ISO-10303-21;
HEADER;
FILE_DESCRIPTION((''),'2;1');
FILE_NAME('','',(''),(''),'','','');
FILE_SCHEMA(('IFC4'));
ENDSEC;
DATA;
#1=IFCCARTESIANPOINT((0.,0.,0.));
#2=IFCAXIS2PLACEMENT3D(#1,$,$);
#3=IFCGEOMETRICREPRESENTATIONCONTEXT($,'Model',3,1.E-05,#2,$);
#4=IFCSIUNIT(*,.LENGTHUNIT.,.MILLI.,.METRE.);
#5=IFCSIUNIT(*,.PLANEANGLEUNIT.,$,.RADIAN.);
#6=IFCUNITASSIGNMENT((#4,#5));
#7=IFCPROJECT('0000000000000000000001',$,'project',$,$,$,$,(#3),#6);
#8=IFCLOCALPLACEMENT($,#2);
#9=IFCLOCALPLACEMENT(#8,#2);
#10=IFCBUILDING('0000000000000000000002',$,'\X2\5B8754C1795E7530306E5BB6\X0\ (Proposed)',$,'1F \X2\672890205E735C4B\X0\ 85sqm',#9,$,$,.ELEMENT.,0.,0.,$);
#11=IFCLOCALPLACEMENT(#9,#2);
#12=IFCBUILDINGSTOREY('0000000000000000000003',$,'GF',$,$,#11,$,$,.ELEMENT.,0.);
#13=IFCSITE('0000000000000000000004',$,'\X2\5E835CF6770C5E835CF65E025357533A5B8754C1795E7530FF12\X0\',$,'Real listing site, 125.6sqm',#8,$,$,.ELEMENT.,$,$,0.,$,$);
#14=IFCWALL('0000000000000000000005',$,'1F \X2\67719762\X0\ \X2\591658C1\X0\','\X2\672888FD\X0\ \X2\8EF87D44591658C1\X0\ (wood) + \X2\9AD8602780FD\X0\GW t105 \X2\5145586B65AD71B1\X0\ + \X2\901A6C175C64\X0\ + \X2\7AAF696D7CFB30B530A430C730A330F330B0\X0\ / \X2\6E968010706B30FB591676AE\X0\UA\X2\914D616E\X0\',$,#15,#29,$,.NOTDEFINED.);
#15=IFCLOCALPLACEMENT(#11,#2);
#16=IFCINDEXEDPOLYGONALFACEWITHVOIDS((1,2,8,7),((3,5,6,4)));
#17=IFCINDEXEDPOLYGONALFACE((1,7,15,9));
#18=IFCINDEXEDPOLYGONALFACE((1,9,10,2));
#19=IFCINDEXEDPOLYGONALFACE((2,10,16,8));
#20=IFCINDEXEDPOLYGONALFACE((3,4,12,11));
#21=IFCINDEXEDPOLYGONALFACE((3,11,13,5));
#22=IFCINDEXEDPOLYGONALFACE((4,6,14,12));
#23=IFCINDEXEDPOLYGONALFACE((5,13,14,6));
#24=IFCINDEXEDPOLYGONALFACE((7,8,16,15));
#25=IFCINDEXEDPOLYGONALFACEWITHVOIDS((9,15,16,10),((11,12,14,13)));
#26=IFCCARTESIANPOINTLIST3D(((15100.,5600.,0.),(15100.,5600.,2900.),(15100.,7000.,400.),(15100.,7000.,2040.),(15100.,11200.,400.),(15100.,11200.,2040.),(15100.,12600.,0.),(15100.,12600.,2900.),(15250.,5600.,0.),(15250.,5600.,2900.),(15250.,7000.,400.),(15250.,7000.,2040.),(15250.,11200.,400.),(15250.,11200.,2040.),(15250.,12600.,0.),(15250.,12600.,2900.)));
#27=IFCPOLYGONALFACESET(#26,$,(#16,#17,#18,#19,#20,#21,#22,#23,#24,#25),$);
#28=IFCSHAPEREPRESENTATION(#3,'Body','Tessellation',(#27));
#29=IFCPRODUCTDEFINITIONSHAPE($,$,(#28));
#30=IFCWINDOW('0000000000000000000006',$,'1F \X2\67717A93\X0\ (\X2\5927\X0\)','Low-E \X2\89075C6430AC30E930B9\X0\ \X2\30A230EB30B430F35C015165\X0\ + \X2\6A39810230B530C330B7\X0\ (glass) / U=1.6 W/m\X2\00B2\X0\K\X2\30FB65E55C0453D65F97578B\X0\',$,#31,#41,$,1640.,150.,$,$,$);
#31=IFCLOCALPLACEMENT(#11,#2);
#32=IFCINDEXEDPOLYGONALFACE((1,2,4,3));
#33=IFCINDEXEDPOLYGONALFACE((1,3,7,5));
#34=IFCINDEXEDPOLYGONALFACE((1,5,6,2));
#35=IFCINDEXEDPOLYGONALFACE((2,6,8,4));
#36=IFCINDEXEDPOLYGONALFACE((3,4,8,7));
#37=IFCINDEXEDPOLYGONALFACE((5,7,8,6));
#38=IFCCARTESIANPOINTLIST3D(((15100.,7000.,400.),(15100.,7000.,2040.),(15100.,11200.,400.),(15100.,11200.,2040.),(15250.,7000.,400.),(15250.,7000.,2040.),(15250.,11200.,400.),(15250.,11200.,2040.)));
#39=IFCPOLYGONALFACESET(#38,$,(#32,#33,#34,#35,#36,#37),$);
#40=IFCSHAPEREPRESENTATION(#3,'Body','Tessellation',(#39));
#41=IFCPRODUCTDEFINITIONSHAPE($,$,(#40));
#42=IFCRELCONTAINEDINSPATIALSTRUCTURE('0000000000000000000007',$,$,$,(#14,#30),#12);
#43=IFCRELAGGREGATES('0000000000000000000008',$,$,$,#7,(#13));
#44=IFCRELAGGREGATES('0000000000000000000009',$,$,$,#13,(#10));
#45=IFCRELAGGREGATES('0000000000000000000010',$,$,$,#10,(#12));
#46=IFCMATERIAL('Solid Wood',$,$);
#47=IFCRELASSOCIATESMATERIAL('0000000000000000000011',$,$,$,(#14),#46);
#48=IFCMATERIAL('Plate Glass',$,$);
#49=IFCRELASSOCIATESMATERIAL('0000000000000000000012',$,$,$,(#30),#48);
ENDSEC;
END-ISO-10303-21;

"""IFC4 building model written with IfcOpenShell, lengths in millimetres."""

from ifc_helpers import new_model, si_unit, frame, frame_2d, origin, place, context, project, spatial, rectangle, extrude, material, element, fill, save


model = new_model("IFC4")

# Units and contexts
model_context = context("Model", 3, precision=1e-05, world=origin())
ifc_project = project(units=[si_unit("LENGTHUNIT", "METRE", prefix="MILLI"), si_unit("PLANEANGLEUNIT", "RADIAN")], contexts=[model_context])

# Site, building, storey
site_placement = place(None, origin())
site = spatial("IfcSite", under=ifc_project, at=site_placement, Name="広島県広島市南区宇品神田２", ObjectType="Real listing site, 125.6sqm", CompositionType="ELEMENT", RefElevation=0.0)
building_placement = place(site_placement, origin())
building = spatial("IfcBuilding", under=site, at=building_placement, Name="宇品神田の家 (Proposed)", ObjectType="1F 木造平屋 85sqm", CompositionType="ELEMENT", ElevationOfRefHeight=0.0, ElevationOfTerrain=0.0)
storey_placement = place(building_placement, origin())
storey = spatial("IfcBuildingStorey", under=building, at=storey_placement, Name="GF", CompositionType="ELEMENT", Elevation=0.0)

# Shared definitions
ifc_material_1 = material(Name="Solid Wood")

# Shared definitions
ifc_material_2 = material(Name="Plate Glass")

# Wall, opening, window
wall_1_placement = place(storey_placement, frame((7550.0, 2800.0, 0.0)))
wall_1 = element("IfcWall", 1, at=wall_1_placement, inside=storey, material=ifc_material_1, Name="1F 東面 外壁", Description="木製 軸組外壁 (wood) + 高性能GW t105 充填断熱 + 通気層 + 窯業系サイディング / 準耐火・外皮UA配慮", PredefinedType="NOTDEFINED", context=model_context, shape_type="SweptSolid", body=[
    extrude(rectangle(XDim=150.0, YDim=7000.0, at=frame_2d((75.0, 3500.0))), frame((7550.0, 2800.0, 0.0)), (0.0, 0.0, 1.0), 2900.0),
])
opening_1_placement = place(storey_placement, frame((7550.0, 3500.0, 200.0)))
opening_1 = element("IfcOpeningElement", 2, at=opening_1_placement, cuts=wall_1, PredefinedType="NOTDEFINED", context=model_context, shape_type="SweptSolid", body=[
    extrude(rectangle(XDim=150.0, YDim=4200.0, at=frame_2d((75.0, 2100.0))), frame((7550.0, 3500.0, 200.0)), (0.0, 0.0, 1.0), 1640.0),
])
window_1_placement = place(storey_placement, frame((7550.0, 3500.0, 200.0)))
window_1 = element("IfcWindow", 3, at=window_1_placement, inside=storey, material=ifc_material_2, Name="1F 東窓 (大)", Description="Low-E 複層ガラス アルゴン封入 + 樹脂サッシ (glass) / U=1.6 W/m²K・日射取得型", OverallHeight=1640.0, OverallWidth=150.0, context=model_context, shape_type="SweptSolid", body=[
    extrude(rectangle(XDim=150.0, YDim=4200.0, at=frame_2d((75.0, 2100.0))), frame((7550.0, 3500.0, 200.0)), (0.0, 0.0, 1.0), 1640.0),
])
fill(opening_1, window_1)

save(model, "model.ifc")
